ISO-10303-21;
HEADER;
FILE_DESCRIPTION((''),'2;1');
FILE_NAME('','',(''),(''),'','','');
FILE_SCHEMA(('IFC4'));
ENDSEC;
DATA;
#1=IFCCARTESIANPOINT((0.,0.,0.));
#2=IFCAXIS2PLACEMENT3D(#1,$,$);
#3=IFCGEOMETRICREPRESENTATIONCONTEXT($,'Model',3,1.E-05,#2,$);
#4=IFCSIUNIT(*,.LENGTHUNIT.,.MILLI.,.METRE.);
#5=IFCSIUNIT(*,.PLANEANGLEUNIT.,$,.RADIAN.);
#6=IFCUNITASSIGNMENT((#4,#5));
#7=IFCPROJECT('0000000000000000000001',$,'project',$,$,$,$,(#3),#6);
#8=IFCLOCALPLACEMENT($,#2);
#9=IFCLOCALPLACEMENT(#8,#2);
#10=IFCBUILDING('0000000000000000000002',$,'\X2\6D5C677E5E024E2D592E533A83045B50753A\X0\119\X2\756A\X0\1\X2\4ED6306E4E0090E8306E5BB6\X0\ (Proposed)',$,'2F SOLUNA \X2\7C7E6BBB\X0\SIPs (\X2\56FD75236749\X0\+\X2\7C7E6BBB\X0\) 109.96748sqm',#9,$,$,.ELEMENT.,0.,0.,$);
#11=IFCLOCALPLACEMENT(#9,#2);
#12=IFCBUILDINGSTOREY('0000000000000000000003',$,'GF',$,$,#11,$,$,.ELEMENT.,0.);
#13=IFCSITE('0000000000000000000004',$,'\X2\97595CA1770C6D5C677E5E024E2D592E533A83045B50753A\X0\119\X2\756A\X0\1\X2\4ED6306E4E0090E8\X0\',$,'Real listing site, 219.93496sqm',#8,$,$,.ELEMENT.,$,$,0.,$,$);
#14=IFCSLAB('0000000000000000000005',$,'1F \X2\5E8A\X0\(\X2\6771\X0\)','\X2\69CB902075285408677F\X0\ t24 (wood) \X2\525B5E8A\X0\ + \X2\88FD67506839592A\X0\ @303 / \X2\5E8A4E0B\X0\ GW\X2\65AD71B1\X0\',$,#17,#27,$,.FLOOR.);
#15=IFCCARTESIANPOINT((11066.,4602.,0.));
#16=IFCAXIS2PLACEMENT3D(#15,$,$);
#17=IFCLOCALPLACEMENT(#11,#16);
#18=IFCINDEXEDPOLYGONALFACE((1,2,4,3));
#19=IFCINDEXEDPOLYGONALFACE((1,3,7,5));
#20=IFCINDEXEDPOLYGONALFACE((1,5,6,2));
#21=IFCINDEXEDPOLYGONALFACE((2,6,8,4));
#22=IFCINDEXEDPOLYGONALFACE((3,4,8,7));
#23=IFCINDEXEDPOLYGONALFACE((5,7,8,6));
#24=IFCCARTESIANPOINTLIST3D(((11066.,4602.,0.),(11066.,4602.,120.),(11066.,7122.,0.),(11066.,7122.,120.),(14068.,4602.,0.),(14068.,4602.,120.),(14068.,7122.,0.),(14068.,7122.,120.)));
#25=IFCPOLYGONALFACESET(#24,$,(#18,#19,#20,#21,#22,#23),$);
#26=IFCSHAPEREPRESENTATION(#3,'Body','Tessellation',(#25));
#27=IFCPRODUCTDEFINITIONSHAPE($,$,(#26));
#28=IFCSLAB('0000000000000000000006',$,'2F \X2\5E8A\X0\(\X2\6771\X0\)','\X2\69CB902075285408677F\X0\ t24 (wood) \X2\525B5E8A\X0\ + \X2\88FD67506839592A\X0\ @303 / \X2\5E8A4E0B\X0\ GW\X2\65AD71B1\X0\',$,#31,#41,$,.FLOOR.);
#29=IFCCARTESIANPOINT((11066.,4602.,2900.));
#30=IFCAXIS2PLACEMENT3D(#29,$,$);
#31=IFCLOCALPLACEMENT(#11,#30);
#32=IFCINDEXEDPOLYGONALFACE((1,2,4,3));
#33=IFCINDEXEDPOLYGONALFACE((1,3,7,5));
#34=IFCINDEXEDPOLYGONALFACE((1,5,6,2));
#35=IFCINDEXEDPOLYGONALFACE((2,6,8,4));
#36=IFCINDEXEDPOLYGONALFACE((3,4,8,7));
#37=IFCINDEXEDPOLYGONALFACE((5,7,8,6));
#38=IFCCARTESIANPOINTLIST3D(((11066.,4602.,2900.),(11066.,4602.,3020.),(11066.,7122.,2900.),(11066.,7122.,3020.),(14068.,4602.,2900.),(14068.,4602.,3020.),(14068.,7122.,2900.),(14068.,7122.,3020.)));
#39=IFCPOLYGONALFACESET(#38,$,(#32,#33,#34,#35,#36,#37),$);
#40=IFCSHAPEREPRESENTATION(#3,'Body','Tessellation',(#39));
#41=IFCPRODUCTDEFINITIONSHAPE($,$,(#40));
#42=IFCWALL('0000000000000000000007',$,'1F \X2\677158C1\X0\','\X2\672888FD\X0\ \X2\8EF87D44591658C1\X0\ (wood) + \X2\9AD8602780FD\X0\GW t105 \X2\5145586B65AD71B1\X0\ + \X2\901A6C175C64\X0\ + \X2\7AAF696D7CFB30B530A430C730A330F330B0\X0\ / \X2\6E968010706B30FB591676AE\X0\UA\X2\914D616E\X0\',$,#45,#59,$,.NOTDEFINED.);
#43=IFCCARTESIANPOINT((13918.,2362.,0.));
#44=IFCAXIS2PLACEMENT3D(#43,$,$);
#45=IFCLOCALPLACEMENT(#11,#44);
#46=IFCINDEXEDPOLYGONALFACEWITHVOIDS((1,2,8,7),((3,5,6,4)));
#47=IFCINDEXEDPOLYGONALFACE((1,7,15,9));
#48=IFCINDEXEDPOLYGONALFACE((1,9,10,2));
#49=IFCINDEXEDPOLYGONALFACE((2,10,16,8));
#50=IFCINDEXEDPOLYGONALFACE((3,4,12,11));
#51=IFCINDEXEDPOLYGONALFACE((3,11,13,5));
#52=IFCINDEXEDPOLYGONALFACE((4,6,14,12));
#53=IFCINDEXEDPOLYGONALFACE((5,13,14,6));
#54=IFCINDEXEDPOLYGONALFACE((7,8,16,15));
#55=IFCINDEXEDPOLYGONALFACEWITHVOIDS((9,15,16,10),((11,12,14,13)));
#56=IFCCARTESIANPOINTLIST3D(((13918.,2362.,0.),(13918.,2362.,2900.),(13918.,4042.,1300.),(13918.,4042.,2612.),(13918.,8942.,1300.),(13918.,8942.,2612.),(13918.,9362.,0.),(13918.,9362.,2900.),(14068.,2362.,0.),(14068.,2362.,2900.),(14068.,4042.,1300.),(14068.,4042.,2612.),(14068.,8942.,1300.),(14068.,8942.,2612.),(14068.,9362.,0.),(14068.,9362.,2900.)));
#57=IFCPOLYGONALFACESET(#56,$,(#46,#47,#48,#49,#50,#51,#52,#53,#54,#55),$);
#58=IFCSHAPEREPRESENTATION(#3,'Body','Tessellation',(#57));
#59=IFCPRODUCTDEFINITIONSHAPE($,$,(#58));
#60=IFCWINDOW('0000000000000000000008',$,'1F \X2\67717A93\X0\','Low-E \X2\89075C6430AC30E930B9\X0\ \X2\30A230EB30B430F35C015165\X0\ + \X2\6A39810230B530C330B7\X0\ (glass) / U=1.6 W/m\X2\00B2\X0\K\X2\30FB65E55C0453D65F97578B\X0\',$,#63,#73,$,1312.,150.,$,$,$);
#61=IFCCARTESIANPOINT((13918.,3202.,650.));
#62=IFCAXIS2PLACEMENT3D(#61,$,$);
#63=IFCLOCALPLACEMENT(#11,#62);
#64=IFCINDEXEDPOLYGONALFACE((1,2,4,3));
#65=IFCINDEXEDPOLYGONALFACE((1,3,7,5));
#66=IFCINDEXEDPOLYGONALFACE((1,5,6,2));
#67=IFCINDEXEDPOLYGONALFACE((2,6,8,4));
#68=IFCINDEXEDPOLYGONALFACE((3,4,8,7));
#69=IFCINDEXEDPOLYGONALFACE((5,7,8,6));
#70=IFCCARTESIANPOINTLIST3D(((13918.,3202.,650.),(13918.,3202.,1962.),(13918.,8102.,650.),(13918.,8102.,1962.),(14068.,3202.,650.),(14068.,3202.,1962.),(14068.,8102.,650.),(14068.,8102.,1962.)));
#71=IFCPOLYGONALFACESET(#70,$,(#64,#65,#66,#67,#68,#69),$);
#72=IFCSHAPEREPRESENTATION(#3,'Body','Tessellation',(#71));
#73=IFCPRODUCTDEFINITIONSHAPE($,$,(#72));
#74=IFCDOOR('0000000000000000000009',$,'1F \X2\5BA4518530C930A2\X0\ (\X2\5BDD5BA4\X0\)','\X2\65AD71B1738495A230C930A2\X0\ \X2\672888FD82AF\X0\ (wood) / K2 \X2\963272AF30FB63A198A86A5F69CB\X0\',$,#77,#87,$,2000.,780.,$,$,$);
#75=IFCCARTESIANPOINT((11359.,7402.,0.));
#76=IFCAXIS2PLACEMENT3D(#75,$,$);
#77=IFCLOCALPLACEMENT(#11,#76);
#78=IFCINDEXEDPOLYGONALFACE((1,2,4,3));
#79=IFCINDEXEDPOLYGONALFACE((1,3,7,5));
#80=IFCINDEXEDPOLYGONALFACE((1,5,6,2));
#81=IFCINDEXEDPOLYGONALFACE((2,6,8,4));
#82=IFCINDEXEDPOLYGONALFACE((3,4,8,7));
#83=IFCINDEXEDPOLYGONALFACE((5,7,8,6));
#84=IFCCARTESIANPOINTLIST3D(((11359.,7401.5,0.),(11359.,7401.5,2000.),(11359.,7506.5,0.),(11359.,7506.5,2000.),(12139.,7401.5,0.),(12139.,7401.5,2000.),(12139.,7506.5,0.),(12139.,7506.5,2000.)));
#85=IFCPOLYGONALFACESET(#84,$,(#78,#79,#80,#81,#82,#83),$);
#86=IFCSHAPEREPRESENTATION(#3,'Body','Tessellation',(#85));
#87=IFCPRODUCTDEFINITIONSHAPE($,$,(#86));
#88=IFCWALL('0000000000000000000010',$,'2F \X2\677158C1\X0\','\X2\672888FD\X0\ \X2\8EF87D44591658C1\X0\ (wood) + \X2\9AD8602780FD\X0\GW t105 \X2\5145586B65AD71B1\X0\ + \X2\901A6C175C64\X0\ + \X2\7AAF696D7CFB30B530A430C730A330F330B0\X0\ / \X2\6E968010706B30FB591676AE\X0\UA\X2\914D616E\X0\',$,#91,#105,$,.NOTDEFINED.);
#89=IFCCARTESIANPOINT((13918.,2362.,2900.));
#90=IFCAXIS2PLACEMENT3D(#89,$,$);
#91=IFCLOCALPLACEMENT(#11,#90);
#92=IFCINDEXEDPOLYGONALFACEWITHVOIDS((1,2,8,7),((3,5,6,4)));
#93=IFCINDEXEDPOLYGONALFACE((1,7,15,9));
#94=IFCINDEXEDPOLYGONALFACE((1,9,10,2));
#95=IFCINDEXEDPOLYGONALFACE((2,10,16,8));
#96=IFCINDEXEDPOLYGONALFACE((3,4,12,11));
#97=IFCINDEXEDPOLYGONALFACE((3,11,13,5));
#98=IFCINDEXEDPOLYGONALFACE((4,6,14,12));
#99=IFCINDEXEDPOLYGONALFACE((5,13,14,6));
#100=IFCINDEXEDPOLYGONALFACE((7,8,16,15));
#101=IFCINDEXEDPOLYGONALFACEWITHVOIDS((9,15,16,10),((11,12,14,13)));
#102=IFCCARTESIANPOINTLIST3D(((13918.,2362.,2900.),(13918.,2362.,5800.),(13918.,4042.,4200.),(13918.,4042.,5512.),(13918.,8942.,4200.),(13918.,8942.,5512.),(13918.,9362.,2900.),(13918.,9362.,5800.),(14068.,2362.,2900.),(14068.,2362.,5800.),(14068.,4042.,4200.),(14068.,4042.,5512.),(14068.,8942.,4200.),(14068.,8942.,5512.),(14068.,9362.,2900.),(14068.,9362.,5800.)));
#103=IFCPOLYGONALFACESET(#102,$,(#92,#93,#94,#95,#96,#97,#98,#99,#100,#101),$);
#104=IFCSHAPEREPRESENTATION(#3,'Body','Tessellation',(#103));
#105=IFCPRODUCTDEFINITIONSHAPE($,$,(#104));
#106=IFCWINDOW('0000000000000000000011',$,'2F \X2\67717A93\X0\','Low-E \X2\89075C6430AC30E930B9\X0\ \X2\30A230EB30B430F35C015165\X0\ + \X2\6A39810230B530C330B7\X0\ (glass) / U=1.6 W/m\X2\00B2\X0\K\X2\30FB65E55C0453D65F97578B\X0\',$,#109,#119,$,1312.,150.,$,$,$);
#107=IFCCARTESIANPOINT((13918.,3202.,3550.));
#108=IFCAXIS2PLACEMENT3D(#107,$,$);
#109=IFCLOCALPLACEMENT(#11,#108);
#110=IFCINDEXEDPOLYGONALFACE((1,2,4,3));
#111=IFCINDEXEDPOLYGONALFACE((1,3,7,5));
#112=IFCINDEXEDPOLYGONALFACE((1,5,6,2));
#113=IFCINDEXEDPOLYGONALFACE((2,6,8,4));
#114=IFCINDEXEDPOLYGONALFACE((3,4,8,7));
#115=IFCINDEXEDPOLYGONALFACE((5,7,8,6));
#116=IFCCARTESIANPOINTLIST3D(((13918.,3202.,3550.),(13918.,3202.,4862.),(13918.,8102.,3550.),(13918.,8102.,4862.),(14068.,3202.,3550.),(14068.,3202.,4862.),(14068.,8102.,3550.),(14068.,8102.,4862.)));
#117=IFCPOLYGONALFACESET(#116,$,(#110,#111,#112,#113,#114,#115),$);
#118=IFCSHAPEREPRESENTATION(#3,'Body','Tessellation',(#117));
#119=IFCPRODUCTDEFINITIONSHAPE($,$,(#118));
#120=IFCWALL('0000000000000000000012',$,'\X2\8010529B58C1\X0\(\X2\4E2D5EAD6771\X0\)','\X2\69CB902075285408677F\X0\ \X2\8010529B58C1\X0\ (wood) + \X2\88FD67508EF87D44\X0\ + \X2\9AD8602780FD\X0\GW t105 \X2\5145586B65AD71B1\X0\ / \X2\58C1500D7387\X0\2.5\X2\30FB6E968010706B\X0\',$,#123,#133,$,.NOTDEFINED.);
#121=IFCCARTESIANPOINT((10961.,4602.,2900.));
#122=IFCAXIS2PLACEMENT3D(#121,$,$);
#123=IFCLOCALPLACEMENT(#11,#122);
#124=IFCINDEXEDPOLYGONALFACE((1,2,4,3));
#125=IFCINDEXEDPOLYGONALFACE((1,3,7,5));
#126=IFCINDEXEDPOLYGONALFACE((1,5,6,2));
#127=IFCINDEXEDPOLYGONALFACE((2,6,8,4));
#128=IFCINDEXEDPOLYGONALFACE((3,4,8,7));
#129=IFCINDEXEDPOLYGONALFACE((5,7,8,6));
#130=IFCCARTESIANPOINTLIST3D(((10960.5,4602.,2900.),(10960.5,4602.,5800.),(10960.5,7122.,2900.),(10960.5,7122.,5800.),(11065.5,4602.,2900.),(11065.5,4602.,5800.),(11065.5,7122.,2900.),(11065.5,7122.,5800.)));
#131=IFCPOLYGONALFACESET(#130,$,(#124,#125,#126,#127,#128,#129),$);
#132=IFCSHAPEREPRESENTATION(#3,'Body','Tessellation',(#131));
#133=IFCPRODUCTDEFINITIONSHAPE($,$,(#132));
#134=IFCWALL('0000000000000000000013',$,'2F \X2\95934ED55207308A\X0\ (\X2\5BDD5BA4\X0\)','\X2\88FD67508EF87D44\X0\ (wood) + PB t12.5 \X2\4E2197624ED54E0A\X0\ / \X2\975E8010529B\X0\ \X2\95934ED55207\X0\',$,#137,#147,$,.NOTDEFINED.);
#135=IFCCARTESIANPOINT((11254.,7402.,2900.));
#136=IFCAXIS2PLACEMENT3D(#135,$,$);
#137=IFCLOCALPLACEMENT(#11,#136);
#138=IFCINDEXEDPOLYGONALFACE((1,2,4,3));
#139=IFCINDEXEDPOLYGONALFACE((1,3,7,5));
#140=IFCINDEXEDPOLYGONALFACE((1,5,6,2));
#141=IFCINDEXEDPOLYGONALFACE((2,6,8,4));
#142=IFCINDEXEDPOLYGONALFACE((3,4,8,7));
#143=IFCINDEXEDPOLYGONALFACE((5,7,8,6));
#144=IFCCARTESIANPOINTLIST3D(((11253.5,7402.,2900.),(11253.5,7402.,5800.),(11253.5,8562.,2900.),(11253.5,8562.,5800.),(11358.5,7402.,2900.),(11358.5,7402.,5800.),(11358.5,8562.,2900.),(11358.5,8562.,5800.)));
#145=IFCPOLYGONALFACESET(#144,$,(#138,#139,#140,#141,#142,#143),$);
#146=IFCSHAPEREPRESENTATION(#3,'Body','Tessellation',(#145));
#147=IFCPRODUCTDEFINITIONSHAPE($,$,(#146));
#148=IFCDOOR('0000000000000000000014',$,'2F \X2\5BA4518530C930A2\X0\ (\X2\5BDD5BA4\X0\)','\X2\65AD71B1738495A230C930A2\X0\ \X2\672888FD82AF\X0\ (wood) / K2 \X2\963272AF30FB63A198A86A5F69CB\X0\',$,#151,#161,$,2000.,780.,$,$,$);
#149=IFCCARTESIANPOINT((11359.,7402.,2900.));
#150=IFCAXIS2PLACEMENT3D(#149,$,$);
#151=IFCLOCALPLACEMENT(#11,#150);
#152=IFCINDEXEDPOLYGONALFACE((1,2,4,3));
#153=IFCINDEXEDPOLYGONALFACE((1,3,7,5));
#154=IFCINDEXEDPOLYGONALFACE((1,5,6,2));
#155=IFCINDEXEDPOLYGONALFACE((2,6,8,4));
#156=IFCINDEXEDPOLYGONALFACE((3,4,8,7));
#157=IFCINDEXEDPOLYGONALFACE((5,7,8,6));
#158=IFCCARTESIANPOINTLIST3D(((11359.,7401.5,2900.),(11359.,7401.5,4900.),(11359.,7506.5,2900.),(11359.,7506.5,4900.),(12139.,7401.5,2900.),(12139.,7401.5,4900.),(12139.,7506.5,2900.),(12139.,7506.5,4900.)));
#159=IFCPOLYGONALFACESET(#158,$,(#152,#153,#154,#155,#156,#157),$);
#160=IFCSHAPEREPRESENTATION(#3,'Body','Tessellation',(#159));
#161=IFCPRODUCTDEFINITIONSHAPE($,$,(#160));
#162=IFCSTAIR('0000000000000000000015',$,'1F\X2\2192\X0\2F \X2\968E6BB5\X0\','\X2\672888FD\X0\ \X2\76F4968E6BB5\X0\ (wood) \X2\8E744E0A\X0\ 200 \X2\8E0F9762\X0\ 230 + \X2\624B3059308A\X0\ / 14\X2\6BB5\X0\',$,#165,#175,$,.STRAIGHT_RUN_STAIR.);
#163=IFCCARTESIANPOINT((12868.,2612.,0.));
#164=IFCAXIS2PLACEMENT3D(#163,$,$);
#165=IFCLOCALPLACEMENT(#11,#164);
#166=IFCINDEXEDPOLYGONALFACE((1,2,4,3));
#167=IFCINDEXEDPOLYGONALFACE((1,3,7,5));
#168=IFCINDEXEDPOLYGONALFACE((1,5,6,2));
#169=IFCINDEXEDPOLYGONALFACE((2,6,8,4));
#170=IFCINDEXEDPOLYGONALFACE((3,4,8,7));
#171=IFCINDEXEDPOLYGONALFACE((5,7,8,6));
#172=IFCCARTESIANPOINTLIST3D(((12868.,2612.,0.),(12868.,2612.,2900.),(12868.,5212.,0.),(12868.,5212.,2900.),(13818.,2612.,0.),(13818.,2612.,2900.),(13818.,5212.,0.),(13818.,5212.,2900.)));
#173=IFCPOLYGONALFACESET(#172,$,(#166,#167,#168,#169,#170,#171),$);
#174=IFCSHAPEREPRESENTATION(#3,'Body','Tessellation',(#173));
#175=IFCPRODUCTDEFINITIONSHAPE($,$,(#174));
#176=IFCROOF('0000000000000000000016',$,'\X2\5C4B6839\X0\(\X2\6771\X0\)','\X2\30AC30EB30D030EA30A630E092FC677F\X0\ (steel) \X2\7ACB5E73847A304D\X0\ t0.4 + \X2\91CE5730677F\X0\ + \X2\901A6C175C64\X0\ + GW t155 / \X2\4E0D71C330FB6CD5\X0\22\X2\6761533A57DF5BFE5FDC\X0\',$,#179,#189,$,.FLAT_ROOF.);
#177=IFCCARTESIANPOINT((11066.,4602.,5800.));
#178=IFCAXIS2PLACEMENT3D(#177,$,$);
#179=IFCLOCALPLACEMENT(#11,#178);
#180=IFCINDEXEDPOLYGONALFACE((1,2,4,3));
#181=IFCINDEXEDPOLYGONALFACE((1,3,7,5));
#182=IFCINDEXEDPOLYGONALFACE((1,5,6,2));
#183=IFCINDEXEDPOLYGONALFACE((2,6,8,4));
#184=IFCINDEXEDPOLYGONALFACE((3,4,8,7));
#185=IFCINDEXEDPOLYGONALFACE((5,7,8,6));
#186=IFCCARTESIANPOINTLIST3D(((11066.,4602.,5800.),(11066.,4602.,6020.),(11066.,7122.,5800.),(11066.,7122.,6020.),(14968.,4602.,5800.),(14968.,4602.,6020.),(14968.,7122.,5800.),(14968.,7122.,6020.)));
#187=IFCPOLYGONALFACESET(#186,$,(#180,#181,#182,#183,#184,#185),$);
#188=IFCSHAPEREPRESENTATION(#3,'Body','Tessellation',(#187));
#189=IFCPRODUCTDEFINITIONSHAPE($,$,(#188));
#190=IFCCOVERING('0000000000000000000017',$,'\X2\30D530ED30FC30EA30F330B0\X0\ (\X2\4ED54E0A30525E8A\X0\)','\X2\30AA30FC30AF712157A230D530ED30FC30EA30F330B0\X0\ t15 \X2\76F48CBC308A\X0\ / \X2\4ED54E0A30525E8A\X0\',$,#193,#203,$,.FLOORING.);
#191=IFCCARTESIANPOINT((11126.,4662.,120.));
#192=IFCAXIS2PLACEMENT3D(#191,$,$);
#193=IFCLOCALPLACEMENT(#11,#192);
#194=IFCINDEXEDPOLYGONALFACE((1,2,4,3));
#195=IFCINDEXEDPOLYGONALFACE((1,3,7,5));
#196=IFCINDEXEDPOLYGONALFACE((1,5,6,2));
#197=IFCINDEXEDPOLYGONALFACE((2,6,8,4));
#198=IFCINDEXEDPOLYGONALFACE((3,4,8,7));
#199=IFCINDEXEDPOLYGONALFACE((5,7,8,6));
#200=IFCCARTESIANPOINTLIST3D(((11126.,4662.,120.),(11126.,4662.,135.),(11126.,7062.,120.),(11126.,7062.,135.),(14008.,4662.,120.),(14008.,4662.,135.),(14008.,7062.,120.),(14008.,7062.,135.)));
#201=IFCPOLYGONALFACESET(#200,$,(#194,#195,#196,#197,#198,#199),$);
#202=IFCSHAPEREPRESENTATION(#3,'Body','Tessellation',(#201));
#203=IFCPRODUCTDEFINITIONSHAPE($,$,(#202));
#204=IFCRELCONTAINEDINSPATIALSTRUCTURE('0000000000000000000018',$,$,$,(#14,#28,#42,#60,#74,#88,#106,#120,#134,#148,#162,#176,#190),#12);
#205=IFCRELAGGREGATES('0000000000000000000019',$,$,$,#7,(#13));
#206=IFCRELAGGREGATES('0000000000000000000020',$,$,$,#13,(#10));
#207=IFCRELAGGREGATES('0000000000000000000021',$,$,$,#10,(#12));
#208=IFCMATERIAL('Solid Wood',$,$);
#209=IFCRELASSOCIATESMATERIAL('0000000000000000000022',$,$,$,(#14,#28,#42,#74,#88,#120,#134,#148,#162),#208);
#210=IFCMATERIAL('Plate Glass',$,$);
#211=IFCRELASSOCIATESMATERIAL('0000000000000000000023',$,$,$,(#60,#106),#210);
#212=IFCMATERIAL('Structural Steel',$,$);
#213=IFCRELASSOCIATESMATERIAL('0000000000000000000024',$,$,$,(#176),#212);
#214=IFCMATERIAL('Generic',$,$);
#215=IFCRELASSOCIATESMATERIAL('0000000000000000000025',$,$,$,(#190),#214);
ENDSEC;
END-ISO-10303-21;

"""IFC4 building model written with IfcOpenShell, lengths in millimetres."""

from ifc_helpers import new_model, si_unit, frame, frame_2d, origin, place, context, project, spatial, rectangle, extrude, material, element, fill, save


model = new_model("IFC4")

# Units and contexts
model_context = context("Model", 3, precision=1e-05, world=origin())
ifc_project = project(units=[si_unit("LENGTHUNIT", "METRE", prefix="MILLI"), si_unit("PLANEANGLEUNIT", "RADIAN")], contexts=[model_context])

# Site, building, storey
site_placement = place(None, origin())
site = spatial("IfcSite", under=ifc_project, at=site_placement, Name="静岡県浜松市中央区茄子町119番1他の一部", ObjectType="Real listing site, 219.93496sqm", CompositionType="ELEMENT", RefElevation=0.0)
building_placement = place(site_placement, origin())
building = spatial("IfcBuilding", under=site, at=building_placement, Name="浜松市中央区茄子町119番1他の一部の家 (Proposed)", ObjectType="2F SOLUNA 籾殻SIPs (国産杉+籾殻) 109.96748sqm", CompositionType="ELEMENT", ElevationOfRefHeight=0.0, ElevationOfTerrain=0.0)
storey_placement = place(building_placement, origin())
storey = spatial("IfcBuildingStorey", under=building, at=storey_placement, Name="GF", CompositionType="ELEMENT", Elevation=0.0)

# Slabs
ifc_material_1 = material(Name="Solid Wood")
slab_1_placement = place(storey_placement, frame((11066.0, 4602.0, 0.0)))
element("IfcSlab", 1, at=slab_1_placement, inside=storey, material=ifc_material_1, Name="1F 床(東)", Description="構造用合板 t24 (wood) 剛床 + 製材根太 @303 / 床下 GW断熱", PredefinedType="FLOOR", context=model_context, shape_type="SweptSolid", body=[
    extrude(rectangle(XDim=3002.0, YDim=2520.0, at=frame_2d((1501.0, 1260.0))), frame((11066.0, 4602.0, 0.0)), (0.0, 0.0, 1.0), 120.0),
])
slab_2_placement = place(storey_placement, frame((11066.0, 4602.0, 2900.0)))
element("IfcSlab", 2, at=slab_2_placement, inside=storey, material=ifc_material_1, Name="2F 床(東)", Description="構造用合板 t24 (wood) 剛床 + 製材根太 @303 / 床下 GW断熱", PredefinedType="FLOOR", context=model_context, shape_type="SweptSolid", body=[
    extrude(rectangle(XDim=3002.0, YDim=2520.0, at=frame_2d((1501.0, 1260.0))), frame((11066.0, 4602.0, 2900.0)), (0.0, 0.0, 1.0), 120.0),
])

# Wall, opening, window
wall_1_placement = place(storey_placement, frame((13918.0, 2362.0, 0.0)))
wall_1 = element("IfcWall", 3, at=wall_1_placement, inside=storey, material=ifc_material_1, Name="1F 東壁", Description="木製 軸組外壁 (wood) + 高性能GW t105 充填断熱 + 通気層 + 窯業系サイディング / 準耐火・外皮UA配慮", PredefinedType="NOTDEFINED", context=model_context, shape_type="SweptSolid", body=[
    extrude(rectangle(XDim=150.0, YDim=7000.0, at=frame_2d((75.0, 3500.0))), frame((13918.0, 2362.0, 0.0)), (0.0, 0.0, 1.0), 2900.0),
])
opening_1_placement = place(storey_placement, frame((13918.0, 3202.0, 650.0)))
opening_1 = element("IfcOpeningElement", 4, at=opening_1_placement, cuts=wall_1, PredefinedType="NOTDEFINED", context=model_context, shape_type="SweptSolid", body=[
    extrude(rectangle(XDim=150.0, YDim=4900.0, at=frame_2d((75.0, 2450.0))), frame((13918.0, 3202.0, 650.0)), (0.0, 0.0, 1.0), 1312.0),
])
ifc_material_2 = material(Name="Plate Glass")
window_1_placement = place(storey_placement, frame((13918.0, 3202.0, 650.0)))
window_1 = element("IfcWindow", 5, at=window_1_placement, inside=storey, material=ifc_material_2, Name="1F 東窓", Description="Low-E 複層ガラス アルゴン封入 + 樹脂サッシ (glass) / U=1.6 W/m²K・日射取得型", OverallHeight=1312.0, OverallWidth=150.0, context=model_context, shape_type="SweptSolid", body=[
    extrude(rectangle(XDim=150.0, YDim=4900.0, at=frame_2d((75.0, 2450.0))), frame((13918.0, 3202.0, 650.0)), (0.0, 0.0, 1.0), 1312.0),
])
fill(opening_1, window_1)

# Door
door_1_placement = place(storey_placement, frame((11359.0, 7402.0, 0.0)))
element("IfcDoor", 6, at=door_1_placement, inside=storey, material=ifc_material_1, Name="1F 室内ドア (寝室)", Description="断熱玄関ドア 木製芯 (wood) / K2 防犯・採風機構", OverallHeight=2000.0, OverallWidth=780.0, context=model_context, shape_type="SweptSolid", body=[
    extrude(rectangle(XDim=780.0, YDim=105.0, at=frame_2d((390.0, 52.0))), frame((11359.0, 7402.0, 0.0)), (0.0, 0.0, 1.0), 2000.0),
])

# Wall, opening, window
wall_2_placement = place(storey_placement, frame((13918.0, 2362.0, 2900.0)))
wall_2 = element("IfcWall", 7, at=wall_2_placement, inside=storey, material=ifc_material_1, Name="2F 東壁", Description="木製 軸組外壁 (wood) + 高性能GW t105 充填断熱 + 通気層 + 窯業系サイディング / 準耐火・外皮UA配慮", PredefinedType="NOTDEFINED", context=model_context, shape_type="SweptSolid", body=[
    extrude(rectangle(XDim=150.0, YDim=7000.0, at=frame_2d((75.0, 3500.0))), frame((13918.0, 2362.0, 2900.0)), (0.0, 0.0, 1.0), 2900.0),
])
opening_2_placement = place(storey_placement, frame((13918.0, 3202.0, 3550.0)))
opening_2 = element("IfcOpeningElement", 8, at=opening_2_placement, cuts=wall_2, PredefinedType="NOTDEFINED", context=model_context, shape_type="SweptSolid", body=[
    extrude(rectangle(XDim=150.0, YDim=4900.0, at=frame_2d((75.0, 2450.0))), frame((13918.0, 3202.0, 3550.0)), (0.0, 0.0, 1.0), 1312.0),
])
window_2_placement = place(storey_placement, frame((13918.0, 3202.0, 3550.0)))
window_2 = element("IfcWindow", 9, at=window_2_placement, inside=storey, material=ifc_material_2, Name="2F 東窓", Description="Low-E 複層ガラス アルゴン封入 + 樹脂サッシ (glass) / U=1.6 W/m²K・日射取得型", OverallHeight=1312.0, OverallWidth=150.0, context=model_context, shape_type="SweptSolid", body=[
    extrude(rectangle(XDim=150.0, YDim=4900.0, at=frame_2d((75.0, 2450.0))), frame((13918.0, 3202.0, 3550.0)), (0.0, 0.0, 1.0), 1312.0),
])
fill(opening_2, window_2)

# Walls
wall_3_placement = place(storey_placement, frame((10961.0, 4602.0, 2900.0)))
element("IfcWall", 10, at=wall_3_placement, inside=storey, material=ifc_material_1, Name="耐力壁(中庭東)", Description="構造用合板 耐力壁 (wood) + 製材軸組 + 高性能GW t105 充填断熱 / 壁倍率2.5・準耐火", PredefinedType="NOTDEFINED", context=model_context, shape_type="SweptSolid", body=[
    extrude(rectangle(XDim=105.0, YDim=2520.0, at=frame_2d((52.0, 1260.0))), frame((10961.0, 4602.0, 2900.0)), (0.0, 0.0, 1.0), 2900.0),
])
wall_4_placement = place(storey_placement, frame((11254.0, 7402.0, 2900.0)))
element("IfcWall", 11, at=wall_4_placement, inside=storey, material=ifc_material_1, Name="2F 間仕切り (寝室)", Description="製材軸組 (wood) + PB t12.5 両面仕上 / 非耐力 間仕切", PredefinedType="NOTDEFINED", context=model_context, shape_type="SweptSolid", body=[
    extrude(rectangle(XDim=105.0, YDim=1160.0, at=frame_2d((52.0, 580.0))), frame((11254.0, 7402.0, 2900.0)), (0.0, 0.0, 1.0), 2900.0),
])

# Door
door_2_placement = place(storey_placement, frame((11359.0, 7402.0, 2900.0)))
element("IfcDoor", 12, at=door_2_placement, inside=storey, material=ifc_material_1, Name="2F 室内ドア (寝室)", Description="断熱玄関ドア 木製芯 (wood) / K2 防犯・採風機構", OverallHeight=2000.0, OverallWidth=780.0, context=model_context, shape_type="SweptSolid", body=[
    extrude(rectangle(XDim=780.0, YDim=105.0, at=frame_2d((390.0, 52.0))), frame((11359.0, 7402.0, 2900.0)), (0.0, 0.0, 1.0), 2000.0),
])

# Stair
stair_placement = place(storey_placement, frame((12868.0, 2612.0, 0.0)))
element("IfcStair", 13, at=stair_placement, inside=storey, material=ifc_material_1, Name="1F→2F 階段", Description="木製 直階段 (wood) 蹴上 200 踏面 230 + 手すり / 14段", PredefinedType="STRAIGHT_RUN_STAIR", context=model_context, shape_type="SweptSolid", body=[
    extrude(rectangle(XDim=950.0, YDim=2600.0, at=frame_2d((475.0, 1300.0))), frame((12868.0, 2612.0, 0.0)), (0.0, 0.0, 1.0), 2900.0),
])

# Roof
ifc_material_3 = material(Name="Structural Steel")
for number, where, name in (
    (14, (11066.0, 4602.0, 5800.0), "屋根(東)"),
):
    element("IfcRoof", number, at=place(storey_placement, frame(where)), inside=storey, material=ifc_material_3, Name=name, Description="ガルバリウム鋼板 (steel) 立平葺き t0.4 + 野地板 + 通気層 + GW t155 / 不燃・法22条区域対応", PredefinedType="FLAT_ROOF", context=model_context, shape_type="SweptSolid", body=[
        extrude(rectangle(XDim=3902.0, YDim=2520.0, at=frame_2d((1951.0, 1260.0))), frame((11066.0, 4602.0, 5800.0)), (0.0, 0.0, 1.0), 220.0),
    ])

# Covering
ifc_material_4 = material(Name="Generic")
covering_1_placement = place(storey_placement, frame((11126.0, 4662.0, 120.0)))
element("IfcCovering", 15, at=covering_1_placement, inside=storey, material=ifc_material_4, Name="フローリング (仕上げ床)", Description="オーク無垢フローリング t15 直貼り / 仕上げ床", PredefinedType="FLOORING", context=model_context, shape_type="SweptSolid", body=[
    extrude(rectangle(XDim=2882.0, YDim=2400.0, at=frame_2d((1441.0, 1200.0))), frame((11126.0, 4662.0, 120.0)), (0.0, 0.0, 1.0), 15.0),
])

save(model, "model.ifc")
